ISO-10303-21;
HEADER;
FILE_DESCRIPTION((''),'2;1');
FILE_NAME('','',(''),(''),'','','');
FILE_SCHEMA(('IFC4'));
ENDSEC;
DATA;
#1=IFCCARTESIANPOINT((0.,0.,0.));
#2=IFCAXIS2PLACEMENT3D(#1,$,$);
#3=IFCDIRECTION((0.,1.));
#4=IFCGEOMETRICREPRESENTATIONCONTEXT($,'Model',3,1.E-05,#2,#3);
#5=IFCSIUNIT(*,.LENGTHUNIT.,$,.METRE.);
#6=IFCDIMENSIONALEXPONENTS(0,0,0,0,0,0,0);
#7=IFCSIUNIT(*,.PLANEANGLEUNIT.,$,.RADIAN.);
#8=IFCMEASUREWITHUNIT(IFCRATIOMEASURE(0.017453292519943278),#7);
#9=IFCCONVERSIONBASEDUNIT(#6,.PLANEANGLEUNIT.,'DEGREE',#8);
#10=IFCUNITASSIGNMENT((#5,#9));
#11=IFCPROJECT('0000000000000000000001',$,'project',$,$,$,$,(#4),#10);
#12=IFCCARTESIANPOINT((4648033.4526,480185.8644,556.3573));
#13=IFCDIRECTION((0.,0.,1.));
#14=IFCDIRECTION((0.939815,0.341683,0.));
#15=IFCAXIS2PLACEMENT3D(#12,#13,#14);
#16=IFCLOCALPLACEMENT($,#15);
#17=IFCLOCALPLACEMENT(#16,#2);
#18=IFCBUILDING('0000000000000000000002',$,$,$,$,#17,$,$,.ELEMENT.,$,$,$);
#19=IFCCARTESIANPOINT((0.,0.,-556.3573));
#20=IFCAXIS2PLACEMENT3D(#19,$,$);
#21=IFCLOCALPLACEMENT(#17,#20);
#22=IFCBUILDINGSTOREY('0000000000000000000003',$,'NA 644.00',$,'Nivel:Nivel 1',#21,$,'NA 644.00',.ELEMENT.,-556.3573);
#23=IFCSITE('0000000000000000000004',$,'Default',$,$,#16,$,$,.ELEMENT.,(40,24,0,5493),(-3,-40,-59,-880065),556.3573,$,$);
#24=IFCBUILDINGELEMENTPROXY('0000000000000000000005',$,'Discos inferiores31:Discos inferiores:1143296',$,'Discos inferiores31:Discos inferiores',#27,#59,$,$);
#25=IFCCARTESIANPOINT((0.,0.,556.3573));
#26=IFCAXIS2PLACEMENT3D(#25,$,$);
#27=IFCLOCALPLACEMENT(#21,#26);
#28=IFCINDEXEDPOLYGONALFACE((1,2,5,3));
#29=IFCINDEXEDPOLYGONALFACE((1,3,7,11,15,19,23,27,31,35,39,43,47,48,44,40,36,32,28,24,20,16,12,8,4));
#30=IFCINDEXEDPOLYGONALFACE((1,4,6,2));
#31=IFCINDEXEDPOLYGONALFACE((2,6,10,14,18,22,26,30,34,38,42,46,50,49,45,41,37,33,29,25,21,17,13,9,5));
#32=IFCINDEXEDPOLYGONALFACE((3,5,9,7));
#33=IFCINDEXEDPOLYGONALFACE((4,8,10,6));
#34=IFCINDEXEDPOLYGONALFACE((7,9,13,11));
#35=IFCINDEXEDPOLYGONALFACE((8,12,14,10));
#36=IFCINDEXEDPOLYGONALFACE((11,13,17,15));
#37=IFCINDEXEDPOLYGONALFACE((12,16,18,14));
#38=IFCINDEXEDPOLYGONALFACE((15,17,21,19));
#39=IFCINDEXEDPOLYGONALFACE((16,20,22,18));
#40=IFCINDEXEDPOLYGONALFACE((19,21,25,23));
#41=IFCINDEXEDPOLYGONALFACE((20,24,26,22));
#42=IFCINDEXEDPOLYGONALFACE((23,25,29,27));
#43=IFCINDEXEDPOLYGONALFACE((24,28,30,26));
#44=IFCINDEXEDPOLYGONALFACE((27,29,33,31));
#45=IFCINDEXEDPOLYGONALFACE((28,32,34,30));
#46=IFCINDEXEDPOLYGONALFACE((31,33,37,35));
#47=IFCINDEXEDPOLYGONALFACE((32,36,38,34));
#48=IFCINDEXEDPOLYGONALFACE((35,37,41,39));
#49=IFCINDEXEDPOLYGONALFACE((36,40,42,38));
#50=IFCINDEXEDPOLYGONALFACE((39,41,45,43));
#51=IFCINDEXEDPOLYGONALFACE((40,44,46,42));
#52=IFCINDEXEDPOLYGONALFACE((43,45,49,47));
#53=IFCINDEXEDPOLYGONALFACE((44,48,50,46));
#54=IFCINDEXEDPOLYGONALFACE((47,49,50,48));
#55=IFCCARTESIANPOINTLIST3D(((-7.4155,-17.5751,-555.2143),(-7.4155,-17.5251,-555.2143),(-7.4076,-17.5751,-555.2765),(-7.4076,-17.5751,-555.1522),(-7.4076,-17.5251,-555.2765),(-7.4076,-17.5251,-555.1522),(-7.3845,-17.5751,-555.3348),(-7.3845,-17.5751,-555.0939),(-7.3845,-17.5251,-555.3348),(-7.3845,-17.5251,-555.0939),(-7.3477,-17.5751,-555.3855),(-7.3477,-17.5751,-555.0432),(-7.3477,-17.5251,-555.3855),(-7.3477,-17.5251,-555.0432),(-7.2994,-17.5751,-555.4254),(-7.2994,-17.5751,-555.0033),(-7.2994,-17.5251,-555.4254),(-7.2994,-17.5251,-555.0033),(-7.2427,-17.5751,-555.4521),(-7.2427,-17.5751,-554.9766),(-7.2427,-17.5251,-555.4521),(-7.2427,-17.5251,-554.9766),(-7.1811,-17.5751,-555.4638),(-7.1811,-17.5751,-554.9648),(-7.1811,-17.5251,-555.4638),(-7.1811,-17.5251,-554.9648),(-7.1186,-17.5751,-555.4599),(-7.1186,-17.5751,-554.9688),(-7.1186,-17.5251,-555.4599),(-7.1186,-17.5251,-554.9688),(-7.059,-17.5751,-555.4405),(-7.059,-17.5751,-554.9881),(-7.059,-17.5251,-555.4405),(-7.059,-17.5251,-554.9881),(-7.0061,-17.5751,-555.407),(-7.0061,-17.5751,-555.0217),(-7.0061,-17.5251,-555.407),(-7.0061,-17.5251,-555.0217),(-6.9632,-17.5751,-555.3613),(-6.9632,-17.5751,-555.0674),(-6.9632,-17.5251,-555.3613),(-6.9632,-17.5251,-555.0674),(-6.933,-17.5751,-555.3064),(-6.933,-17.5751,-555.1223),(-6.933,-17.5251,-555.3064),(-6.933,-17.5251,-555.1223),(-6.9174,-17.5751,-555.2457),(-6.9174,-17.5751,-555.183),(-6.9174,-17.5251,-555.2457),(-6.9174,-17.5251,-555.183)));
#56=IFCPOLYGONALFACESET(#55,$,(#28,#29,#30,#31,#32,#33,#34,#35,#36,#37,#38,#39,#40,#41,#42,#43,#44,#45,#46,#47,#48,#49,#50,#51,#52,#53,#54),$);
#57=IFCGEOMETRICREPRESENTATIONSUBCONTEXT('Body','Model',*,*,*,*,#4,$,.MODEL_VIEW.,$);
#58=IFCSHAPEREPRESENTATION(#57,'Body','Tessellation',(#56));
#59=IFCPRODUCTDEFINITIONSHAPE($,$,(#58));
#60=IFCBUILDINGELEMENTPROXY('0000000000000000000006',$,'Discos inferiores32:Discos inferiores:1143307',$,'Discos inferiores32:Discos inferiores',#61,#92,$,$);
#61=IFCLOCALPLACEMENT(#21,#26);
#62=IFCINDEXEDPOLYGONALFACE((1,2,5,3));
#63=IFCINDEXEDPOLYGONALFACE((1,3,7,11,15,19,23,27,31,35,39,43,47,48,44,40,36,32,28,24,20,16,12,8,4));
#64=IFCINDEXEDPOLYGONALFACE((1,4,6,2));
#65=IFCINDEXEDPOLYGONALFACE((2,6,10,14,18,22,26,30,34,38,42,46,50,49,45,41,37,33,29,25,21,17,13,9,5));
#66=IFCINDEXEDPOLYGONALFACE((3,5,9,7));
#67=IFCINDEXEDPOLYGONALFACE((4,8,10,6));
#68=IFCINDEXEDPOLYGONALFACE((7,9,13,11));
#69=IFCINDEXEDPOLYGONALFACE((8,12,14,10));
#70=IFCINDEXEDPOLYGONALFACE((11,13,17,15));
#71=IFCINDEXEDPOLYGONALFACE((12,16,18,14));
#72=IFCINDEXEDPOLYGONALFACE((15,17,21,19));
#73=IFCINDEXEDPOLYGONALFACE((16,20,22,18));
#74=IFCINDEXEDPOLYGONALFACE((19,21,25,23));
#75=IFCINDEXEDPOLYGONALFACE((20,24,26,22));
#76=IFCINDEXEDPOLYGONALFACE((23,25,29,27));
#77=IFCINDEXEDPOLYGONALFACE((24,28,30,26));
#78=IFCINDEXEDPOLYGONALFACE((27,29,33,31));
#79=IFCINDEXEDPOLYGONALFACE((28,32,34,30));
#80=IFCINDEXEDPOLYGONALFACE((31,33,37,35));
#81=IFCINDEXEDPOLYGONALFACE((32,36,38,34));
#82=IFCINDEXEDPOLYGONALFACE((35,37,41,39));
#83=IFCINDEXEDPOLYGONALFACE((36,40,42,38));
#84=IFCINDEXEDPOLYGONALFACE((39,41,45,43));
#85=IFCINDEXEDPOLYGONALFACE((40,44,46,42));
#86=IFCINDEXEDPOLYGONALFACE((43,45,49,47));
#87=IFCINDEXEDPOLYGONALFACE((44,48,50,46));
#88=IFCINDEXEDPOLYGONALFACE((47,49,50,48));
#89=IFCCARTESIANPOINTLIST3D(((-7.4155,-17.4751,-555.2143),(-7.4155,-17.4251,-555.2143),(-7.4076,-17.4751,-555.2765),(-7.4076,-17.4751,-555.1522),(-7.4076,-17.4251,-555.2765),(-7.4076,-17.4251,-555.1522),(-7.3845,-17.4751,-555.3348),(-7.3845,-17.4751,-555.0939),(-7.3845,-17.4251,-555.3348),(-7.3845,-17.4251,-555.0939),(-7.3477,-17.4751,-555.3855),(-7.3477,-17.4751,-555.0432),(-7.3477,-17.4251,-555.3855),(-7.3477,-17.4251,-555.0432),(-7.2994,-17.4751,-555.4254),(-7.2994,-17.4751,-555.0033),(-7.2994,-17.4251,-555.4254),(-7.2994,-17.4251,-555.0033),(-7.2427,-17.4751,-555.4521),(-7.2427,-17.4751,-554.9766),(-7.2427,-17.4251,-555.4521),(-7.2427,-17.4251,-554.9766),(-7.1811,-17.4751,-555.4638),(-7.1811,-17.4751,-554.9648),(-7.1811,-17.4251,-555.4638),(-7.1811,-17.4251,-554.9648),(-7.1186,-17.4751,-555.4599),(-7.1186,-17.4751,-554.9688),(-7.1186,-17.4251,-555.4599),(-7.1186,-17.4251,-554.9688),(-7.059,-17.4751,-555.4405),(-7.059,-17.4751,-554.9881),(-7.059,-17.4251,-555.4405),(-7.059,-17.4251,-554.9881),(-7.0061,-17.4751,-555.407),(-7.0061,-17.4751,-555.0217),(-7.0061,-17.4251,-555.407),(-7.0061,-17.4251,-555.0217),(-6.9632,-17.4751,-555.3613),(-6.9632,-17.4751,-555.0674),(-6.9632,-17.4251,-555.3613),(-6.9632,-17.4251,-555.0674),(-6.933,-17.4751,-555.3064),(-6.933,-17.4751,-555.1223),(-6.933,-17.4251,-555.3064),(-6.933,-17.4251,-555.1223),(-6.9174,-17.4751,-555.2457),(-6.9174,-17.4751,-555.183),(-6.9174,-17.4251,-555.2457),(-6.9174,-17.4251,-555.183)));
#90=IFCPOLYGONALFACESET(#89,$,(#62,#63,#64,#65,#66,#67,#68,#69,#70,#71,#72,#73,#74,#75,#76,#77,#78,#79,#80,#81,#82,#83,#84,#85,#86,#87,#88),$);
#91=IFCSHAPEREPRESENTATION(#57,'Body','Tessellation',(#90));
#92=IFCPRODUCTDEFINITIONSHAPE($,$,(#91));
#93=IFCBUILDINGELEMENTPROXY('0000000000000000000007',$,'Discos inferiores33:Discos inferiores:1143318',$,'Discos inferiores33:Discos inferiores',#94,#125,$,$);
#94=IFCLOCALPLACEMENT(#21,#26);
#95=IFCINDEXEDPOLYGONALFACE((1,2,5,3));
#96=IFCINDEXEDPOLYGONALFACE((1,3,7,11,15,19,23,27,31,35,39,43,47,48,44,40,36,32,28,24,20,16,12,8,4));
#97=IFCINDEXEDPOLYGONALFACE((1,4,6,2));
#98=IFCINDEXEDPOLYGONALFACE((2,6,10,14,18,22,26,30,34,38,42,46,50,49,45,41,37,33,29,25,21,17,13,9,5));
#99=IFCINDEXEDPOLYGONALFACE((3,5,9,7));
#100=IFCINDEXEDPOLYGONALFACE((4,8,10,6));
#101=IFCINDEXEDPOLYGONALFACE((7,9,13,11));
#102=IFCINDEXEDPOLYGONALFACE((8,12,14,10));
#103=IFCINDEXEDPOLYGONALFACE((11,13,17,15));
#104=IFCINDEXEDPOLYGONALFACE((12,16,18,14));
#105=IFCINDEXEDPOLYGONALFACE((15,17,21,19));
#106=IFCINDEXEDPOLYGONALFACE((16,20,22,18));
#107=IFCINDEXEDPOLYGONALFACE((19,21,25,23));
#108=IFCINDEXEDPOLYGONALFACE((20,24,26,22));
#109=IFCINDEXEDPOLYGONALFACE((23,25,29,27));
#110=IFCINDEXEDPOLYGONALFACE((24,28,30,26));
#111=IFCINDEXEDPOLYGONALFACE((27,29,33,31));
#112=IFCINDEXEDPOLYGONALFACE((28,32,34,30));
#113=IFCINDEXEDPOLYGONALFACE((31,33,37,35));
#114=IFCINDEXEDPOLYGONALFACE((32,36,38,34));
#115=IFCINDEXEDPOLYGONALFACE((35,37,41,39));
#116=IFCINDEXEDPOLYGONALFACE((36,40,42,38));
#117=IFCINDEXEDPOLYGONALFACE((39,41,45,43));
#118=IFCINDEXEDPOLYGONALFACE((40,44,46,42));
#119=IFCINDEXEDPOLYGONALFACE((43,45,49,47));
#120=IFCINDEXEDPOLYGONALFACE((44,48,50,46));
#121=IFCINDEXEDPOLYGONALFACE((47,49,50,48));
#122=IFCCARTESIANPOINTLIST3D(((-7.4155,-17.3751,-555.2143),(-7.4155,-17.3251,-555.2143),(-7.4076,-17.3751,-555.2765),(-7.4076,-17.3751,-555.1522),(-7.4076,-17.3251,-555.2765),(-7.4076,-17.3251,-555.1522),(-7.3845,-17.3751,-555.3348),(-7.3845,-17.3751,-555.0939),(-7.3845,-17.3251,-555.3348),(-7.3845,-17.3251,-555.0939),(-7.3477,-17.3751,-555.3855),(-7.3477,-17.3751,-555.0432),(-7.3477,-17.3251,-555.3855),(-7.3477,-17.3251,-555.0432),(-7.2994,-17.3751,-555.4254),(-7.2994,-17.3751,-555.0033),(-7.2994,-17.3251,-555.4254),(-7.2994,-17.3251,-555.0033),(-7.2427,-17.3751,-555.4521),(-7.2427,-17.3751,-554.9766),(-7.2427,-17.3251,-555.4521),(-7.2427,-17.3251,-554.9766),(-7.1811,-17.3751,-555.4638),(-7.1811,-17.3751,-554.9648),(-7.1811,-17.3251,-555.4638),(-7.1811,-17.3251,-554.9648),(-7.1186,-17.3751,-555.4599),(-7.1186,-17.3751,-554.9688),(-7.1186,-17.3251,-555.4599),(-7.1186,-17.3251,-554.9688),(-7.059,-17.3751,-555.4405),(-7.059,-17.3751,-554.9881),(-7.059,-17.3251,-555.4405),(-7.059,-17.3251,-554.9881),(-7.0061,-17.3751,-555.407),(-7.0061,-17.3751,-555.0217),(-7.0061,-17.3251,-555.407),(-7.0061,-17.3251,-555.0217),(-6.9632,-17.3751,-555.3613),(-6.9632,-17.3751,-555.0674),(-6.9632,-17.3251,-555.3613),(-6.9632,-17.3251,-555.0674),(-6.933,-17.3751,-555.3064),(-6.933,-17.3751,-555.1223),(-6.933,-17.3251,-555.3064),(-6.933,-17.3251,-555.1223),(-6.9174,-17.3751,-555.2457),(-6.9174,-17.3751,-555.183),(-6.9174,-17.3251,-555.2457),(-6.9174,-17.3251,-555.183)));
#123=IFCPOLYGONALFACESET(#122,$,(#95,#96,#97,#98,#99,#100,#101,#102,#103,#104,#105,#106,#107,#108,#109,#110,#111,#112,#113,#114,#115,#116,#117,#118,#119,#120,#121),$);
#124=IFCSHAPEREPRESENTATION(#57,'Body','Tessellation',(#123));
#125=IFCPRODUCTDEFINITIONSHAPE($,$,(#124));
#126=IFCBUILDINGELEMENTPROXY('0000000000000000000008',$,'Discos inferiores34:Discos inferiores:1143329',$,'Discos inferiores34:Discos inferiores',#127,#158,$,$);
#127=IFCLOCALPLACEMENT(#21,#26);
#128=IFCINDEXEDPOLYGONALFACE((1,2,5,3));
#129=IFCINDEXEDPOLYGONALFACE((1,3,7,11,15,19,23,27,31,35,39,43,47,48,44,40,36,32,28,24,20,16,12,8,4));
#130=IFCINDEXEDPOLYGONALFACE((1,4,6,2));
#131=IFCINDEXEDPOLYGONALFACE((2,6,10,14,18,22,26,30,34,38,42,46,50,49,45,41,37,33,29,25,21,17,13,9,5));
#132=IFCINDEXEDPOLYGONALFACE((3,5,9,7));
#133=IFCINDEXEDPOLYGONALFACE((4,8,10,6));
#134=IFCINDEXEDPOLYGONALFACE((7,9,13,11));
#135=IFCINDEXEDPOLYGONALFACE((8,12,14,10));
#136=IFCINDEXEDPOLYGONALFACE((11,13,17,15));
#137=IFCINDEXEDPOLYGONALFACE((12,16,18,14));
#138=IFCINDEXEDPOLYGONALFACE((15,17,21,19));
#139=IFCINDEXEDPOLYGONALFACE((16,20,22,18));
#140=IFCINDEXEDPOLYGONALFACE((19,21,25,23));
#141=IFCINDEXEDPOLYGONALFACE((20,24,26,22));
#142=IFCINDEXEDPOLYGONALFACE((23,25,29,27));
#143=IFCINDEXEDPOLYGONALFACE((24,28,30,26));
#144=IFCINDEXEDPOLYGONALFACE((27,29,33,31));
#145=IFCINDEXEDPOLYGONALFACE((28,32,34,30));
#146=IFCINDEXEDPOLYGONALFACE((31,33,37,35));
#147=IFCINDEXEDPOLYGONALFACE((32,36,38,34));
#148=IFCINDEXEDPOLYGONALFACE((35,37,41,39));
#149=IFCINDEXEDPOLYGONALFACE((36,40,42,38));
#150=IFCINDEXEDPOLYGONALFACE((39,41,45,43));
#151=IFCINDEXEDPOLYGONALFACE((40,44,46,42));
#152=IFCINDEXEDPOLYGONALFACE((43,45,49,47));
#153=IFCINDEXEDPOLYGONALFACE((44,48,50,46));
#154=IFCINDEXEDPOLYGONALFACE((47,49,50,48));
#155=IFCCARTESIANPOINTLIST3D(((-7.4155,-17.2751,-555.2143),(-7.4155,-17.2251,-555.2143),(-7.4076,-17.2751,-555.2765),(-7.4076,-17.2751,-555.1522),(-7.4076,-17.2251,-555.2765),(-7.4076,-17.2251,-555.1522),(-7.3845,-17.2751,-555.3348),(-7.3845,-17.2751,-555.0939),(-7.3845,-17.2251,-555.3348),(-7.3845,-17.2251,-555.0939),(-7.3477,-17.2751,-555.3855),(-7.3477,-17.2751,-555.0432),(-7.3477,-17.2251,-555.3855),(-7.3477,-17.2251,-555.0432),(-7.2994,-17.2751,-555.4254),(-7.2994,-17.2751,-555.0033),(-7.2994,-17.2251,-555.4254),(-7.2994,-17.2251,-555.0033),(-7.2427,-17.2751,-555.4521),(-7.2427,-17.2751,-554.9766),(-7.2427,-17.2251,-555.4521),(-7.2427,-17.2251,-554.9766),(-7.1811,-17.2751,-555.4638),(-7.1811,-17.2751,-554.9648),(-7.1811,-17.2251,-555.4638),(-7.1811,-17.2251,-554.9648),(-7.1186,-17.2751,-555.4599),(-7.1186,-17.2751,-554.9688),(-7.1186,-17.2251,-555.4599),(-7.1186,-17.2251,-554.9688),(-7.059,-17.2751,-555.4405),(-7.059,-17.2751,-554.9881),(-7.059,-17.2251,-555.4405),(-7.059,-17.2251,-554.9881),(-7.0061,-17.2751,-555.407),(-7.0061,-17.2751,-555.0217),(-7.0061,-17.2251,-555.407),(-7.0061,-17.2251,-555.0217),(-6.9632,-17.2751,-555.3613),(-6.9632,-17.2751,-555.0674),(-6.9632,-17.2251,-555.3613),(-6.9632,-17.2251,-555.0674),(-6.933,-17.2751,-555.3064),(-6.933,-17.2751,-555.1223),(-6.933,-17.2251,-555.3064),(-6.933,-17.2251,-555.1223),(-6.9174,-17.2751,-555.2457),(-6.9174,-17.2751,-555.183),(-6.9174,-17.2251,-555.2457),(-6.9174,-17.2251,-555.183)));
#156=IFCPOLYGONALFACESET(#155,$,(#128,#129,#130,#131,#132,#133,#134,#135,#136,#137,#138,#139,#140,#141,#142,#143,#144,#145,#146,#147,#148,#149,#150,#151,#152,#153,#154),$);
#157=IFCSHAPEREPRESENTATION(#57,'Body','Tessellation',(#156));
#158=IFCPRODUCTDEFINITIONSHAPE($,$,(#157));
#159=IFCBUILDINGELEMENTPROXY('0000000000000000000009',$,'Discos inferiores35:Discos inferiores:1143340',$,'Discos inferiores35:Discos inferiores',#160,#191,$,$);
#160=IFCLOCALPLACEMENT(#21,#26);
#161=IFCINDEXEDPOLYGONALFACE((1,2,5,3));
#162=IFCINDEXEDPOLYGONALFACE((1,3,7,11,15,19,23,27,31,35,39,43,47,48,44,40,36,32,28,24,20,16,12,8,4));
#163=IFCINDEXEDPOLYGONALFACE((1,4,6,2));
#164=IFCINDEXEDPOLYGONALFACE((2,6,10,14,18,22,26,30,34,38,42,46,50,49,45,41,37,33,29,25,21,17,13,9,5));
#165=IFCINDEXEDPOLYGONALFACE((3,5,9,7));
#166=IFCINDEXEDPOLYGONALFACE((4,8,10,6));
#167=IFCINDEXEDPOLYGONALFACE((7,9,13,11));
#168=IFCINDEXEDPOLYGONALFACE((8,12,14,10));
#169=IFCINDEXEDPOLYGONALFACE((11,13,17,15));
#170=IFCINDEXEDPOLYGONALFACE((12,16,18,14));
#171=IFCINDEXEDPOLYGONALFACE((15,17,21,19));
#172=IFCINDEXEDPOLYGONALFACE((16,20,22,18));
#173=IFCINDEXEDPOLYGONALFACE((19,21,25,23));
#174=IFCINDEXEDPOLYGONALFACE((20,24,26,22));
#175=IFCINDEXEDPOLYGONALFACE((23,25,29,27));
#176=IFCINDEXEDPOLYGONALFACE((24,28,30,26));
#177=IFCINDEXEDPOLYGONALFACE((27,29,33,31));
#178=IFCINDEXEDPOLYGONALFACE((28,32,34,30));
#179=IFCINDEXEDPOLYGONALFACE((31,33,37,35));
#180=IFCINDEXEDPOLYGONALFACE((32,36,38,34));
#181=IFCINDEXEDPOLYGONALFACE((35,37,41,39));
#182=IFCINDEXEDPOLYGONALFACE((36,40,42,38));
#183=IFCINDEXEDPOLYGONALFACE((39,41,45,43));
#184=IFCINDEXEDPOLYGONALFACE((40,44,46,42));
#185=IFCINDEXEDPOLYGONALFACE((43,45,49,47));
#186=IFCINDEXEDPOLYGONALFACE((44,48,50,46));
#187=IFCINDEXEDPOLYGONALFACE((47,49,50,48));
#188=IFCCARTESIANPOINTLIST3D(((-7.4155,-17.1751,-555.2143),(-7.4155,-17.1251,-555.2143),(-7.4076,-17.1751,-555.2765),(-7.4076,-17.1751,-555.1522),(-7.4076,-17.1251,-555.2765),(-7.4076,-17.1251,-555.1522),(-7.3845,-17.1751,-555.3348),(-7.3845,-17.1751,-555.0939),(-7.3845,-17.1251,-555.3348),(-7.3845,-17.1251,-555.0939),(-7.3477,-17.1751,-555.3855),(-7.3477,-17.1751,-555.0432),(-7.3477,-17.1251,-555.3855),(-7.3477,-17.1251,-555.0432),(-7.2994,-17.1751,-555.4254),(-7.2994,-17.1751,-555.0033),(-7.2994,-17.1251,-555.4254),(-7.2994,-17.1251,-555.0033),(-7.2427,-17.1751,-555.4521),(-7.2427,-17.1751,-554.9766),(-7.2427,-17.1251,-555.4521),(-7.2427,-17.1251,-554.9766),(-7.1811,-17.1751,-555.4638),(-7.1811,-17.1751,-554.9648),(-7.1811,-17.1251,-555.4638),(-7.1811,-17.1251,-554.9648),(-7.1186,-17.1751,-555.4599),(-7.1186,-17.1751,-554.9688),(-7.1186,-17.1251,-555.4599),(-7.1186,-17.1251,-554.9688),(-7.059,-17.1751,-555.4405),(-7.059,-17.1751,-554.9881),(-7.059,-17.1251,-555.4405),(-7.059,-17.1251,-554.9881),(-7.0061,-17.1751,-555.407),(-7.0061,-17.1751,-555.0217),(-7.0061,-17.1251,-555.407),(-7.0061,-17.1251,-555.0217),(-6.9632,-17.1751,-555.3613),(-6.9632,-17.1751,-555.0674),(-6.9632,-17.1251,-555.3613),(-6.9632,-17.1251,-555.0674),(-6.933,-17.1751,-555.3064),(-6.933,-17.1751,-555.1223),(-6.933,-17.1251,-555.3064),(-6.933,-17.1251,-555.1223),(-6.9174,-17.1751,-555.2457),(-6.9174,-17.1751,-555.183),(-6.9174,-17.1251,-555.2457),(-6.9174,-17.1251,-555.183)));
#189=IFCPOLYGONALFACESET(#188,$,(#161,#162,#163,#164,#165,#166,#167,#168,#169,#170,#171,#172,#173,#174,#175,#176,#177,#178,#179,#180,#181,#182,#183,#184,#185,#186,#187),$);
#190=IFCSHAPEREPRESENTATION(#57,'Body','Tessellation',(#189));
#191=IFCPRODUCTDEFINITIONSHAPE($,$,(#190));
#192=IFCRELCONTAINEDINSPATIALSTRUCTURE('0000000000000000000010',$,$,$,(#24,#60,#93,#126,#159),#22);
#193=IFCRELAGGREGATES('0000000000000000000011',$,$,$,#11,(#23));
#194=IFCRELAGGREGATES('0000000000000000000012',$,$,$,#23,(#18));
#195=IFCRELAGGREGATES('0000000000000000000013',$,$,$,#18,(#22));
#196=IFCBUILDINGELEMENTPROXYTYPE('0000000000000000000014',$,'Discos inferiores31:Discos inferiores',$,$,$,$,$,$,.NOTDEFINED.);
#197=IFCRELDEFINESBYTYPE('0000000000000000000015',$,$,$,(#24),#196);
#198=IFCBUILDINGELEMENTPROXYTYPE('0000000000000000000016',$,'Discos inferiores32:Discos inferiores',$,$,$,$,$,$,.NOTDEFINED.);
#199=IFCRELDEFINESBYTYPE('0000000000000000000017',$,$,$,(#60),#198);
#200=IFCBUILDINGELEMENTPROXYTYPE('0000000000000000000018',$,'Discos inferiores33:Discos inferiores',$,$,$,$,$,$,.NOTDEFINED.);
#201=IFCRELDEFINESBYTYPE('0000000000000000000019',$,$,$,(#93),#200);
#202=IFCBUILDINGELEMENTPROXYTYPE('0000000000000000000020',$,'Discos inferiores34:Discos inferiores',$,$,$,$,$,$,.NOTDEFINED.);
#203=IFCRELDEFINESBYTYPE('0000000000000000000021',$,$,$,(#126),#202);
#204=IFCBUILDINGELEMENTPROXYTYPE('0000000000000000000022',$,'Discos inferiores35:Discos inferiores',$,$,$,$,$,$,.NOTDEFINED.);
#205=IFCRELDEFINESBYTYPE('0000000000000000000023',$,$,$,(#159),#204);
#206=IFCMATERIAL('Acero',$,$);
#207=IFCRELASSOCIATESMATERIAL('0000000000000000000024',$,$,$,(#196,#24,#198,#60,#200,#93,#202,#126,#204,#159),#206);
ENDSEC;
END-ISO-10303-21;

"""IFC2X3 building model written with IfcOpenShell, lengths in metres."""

from ifc_helpers import new_model, entity, si_unit, converted_unit, direction, frame, origin, origin_2d_with_axis, place, context, subcontext, project, spatial, circle, extrude, source, transform, mapped, material, type_object, type_shapes, element, save


model = new_model("IFC2X3")

# Units and contexts
model_context = context("Model", 3, precision=1e-05, world=origin(), true_north=direction((0.0, 1.0)))
body_context = subcontext(model_context, "Body", "Model", "MODEL_VIEW")
ifc_project = project(units=[si_unit("LENGTHUNIT", "METRE"), converted_unit("PLANEANGLEUNIT", "DEGREE", entity("IfcRatioMeasure", 0.017453292519943278), si_unit("PLANEANGLEUNIT", "RADIAN"), dimensions=[0, 0, 0, 0, 0, 0, 0])], contexts=[model_context])

# Site, building, storey
site_placement = place(None, frame((4648033.4526, 480185.8644, 556.3573), z_axis=(0.0, 0.0, 1.0), x_axis=(0.939815, 0.341683, 0.0)))
site = spatial("IfcSite", under=ifc_project, at=site_placement, Name="Default", CompositionType="ELEMENT", RefLatitude=(40, 24, 0, 5493), RefLongitude=(-3, -40, -59, -880065), RefElevation=556.3573)
building_placement = place(site_placement, origin())
building = spatial("IfcBuilding", under=site, at=building_placement, CompositionType="ELEMENT")
storey_placement = place(building_placement, frame((0.0, 0.0, -556.3573)))
storey = spatial("IfcBuildingStorey", under=building, at=storey_placement, Name="NA 644.00", ObjectType="Nivel:Nivel 1", LongName="NA 644.00", CompositionType="ELEMENT", Elevation=-556.3573)

# Building element proxies
ifc_material_1 = material(Name="Acero")
building_element_proxy_type_1 = type_object("IfcBuildingElementProxyType", Name="Discos inferiores31:Discos inferiores", PredefinedType="NOTDEFINED", material=ifc_material_1)
shared_shape_1 = source(origin(), body_context, "Body", "SweptSolid", [
    extrude(circle(Radius=0.25, at=origin_2d_with_axis()), frame((-7.1655, -17.5751, -555.2143), z_axis=(0.0, 1.0, 0.0), x_axis=(-1.0, 0.0, 0.0)), (0.0, 0.0, 1.0), 0.05),
])
type_shapes(building_element_proxy_type_1, [shared_shape_1])
proxy_1_placement = place(storey_placement, frame((0.0, 0.0, 556.3573)))
element("IfcBuildingElementProxy", 1, at=proxy_1_placement, inside=storey, type_object=building_element_proxy_type_1, material=ifc_material_1, Name="Discos inferiores31:Discos inferiores:1143296", ObjectType="Discos inferiores31:Discos inferiores", context=body_context, shape_type="MappedRepresentation", body=[
    mapped(shared_shape_1, transform((0.0, 0.0, 0.0), scale=1.0)),
])
building_element_proxy_type_2 = type_object("IfcBuildingElementProxyType", Name="Discos inferiores32:Discos inferiores", PredefinedType="NOTDEFINED", material=ifc_material_1)
shared_shape_2 = source(origin(), body_context, "Body", "SweptSolid", [
    extrude(circle(Radius=0.25, at=origin_2d_with_axis()), frame((-7.1655, -17.4751, -555.2143), z_axis=(0.0, 1.0, 0.0), x_axis=(-1.0, 0.0, 0.0)), (0.0, 0.0, 1.0), 0.05),
])
type_shapes(building_element_proxy_type_2, [shared_shape_2])
proxy_2_placement = place(storey_placement, frame((0.0, 0.0, 556.3573)))
element("IfcBuildingElementProxy", 2, at=proxy_2_placement, inside=storey, type_object=building_element_proxy_type_2, material=ifc_material_1, Name="Discos inferiores32:Discos inferiores:1143307", ObjectType="Discos inferiores32:Discos inferiores", context=body_context, shape_type="MappedRepresentation", body=[
    mapped(shared_shape_2, transform((0.0, 0.0, 0.0), scale=1.0)),
])
building_element_proxy_type_3 = type_object("IfcBuildingElementProxyType", Name="Discos inferiores33:Discos inferiores", PredefinedType="NOTDEFINED", material=ifc_material_1)
shared_shape_3 = source(origin(), body_context, "Body", "SweptSolid", [
    extrude(circle(Radius=0.25, at=origin_2d_with_axis()), frame((-7.1655, -17.3751, -555.2143), z_axis=(0.0, 1.0, 0.0), x_axis=(-1.0, 0.0, 0.0)), (0.0, 0.0, 1.0), 0.05),
])
type_shapes(building_element_proxy_type_3, [shared_shape_3])
proxy_3_placement = place(storey_placement, frame((0.0, 0.0, 556.3573)))
element("IfcBuildingElementProxy", 3, at=proxy_3_placement, inside=storey, type_object=building_element_proxy_type_3, material=ifc_material_1, Name="Discos inferiores33:Discos inferiores:1143318", ObjectType="Discos inferiores33:Discos inferiores", context=body_context, shape_type="MappedRepresentation", body=[
    mapped(shared_shape_3, transform((0.0, 0.0, 0.0), scale=1.0)),
])
building_element_proxy_type_4 = type_object("IfcBuildingElementProxyType", Name="Discos inferiores34:Discos inferiores", PredefinedType="NOTDEFINED", material=ifc_material_1)
shared_shape_4 = source(origin(), body_context, "Body", "SweptSolid", [
    extrude(circle(Radius=0.25, at=origin_2d_with_axis()), frame((-7.1655, -17.2751, -555.2143), z_axis=(0.0, 1.0, 0.0), x_axis=(-1.0, 0.0, 0.0)), (0.0, 0.0, 1.0), 0.05),
])
type_shapes(building_element_proxy_type_4, [shared_shape_4])
proxy_4_placement = place(storey_placement, frame((0.0, 0.0, 556.3573)))
element("IfcBuildingElementProxy", 4, at=proxy_4_placement, inside=storey, type_object=building_element_proxy_type_4, material=ifc_material_1, Name="Discos inferiores34:Discos inferiores:1143329", ObjectType="Discos inferiores34:Discos inferiores", context=body_context, shape_type="MappedRepresentation", body=[
    mapped(shared_shape_4, transform((0.0, 0.0, 0.0), scale=1.0)),
])
building_element_proxy_type_5 = type_object("IfcBuildingElementProxyType", Name="Discos inferiores35:Discos inferiores", PredefinedType="NOTDEFINED", material=ifc_material_1)
shared_shape_5 = source(origin(), body_context, "Body", "SweptSolid", [
    extrude(circle(Radius=0.25, at=origin_2d_with_axis()), frame((-7.1655, -17.1751, -555.2143), z_axis=(0.0, 1.0, 0.0), x_axis=(-1.0, 0.0, 0.0)), (0.0, 0.0, 1.0), 0.05),
])
type_shapes(building_element_proxy_type_5, [shared_shape_5])
proxy_5_placement = place(storey_placement, frame((0.0, 0.0, 556.3573)))
element("IfcBuildingElementProxy", 5, at=proxy_5_placement, inside=storey, type_object=building_element_proxy_type_5, material=ifc_material_1, Name="Discos inferiores35:Discos inferiores:1143340", ObjectType="Discos inferiores35:Discos inferiores", context=body_context, shape_type="MappedRepresentation", body=[
    mapped(shared_shape_5, transform((0.0, 0.0, 0.0), scale=1.0)),
])

save(model, "model.ifc")
